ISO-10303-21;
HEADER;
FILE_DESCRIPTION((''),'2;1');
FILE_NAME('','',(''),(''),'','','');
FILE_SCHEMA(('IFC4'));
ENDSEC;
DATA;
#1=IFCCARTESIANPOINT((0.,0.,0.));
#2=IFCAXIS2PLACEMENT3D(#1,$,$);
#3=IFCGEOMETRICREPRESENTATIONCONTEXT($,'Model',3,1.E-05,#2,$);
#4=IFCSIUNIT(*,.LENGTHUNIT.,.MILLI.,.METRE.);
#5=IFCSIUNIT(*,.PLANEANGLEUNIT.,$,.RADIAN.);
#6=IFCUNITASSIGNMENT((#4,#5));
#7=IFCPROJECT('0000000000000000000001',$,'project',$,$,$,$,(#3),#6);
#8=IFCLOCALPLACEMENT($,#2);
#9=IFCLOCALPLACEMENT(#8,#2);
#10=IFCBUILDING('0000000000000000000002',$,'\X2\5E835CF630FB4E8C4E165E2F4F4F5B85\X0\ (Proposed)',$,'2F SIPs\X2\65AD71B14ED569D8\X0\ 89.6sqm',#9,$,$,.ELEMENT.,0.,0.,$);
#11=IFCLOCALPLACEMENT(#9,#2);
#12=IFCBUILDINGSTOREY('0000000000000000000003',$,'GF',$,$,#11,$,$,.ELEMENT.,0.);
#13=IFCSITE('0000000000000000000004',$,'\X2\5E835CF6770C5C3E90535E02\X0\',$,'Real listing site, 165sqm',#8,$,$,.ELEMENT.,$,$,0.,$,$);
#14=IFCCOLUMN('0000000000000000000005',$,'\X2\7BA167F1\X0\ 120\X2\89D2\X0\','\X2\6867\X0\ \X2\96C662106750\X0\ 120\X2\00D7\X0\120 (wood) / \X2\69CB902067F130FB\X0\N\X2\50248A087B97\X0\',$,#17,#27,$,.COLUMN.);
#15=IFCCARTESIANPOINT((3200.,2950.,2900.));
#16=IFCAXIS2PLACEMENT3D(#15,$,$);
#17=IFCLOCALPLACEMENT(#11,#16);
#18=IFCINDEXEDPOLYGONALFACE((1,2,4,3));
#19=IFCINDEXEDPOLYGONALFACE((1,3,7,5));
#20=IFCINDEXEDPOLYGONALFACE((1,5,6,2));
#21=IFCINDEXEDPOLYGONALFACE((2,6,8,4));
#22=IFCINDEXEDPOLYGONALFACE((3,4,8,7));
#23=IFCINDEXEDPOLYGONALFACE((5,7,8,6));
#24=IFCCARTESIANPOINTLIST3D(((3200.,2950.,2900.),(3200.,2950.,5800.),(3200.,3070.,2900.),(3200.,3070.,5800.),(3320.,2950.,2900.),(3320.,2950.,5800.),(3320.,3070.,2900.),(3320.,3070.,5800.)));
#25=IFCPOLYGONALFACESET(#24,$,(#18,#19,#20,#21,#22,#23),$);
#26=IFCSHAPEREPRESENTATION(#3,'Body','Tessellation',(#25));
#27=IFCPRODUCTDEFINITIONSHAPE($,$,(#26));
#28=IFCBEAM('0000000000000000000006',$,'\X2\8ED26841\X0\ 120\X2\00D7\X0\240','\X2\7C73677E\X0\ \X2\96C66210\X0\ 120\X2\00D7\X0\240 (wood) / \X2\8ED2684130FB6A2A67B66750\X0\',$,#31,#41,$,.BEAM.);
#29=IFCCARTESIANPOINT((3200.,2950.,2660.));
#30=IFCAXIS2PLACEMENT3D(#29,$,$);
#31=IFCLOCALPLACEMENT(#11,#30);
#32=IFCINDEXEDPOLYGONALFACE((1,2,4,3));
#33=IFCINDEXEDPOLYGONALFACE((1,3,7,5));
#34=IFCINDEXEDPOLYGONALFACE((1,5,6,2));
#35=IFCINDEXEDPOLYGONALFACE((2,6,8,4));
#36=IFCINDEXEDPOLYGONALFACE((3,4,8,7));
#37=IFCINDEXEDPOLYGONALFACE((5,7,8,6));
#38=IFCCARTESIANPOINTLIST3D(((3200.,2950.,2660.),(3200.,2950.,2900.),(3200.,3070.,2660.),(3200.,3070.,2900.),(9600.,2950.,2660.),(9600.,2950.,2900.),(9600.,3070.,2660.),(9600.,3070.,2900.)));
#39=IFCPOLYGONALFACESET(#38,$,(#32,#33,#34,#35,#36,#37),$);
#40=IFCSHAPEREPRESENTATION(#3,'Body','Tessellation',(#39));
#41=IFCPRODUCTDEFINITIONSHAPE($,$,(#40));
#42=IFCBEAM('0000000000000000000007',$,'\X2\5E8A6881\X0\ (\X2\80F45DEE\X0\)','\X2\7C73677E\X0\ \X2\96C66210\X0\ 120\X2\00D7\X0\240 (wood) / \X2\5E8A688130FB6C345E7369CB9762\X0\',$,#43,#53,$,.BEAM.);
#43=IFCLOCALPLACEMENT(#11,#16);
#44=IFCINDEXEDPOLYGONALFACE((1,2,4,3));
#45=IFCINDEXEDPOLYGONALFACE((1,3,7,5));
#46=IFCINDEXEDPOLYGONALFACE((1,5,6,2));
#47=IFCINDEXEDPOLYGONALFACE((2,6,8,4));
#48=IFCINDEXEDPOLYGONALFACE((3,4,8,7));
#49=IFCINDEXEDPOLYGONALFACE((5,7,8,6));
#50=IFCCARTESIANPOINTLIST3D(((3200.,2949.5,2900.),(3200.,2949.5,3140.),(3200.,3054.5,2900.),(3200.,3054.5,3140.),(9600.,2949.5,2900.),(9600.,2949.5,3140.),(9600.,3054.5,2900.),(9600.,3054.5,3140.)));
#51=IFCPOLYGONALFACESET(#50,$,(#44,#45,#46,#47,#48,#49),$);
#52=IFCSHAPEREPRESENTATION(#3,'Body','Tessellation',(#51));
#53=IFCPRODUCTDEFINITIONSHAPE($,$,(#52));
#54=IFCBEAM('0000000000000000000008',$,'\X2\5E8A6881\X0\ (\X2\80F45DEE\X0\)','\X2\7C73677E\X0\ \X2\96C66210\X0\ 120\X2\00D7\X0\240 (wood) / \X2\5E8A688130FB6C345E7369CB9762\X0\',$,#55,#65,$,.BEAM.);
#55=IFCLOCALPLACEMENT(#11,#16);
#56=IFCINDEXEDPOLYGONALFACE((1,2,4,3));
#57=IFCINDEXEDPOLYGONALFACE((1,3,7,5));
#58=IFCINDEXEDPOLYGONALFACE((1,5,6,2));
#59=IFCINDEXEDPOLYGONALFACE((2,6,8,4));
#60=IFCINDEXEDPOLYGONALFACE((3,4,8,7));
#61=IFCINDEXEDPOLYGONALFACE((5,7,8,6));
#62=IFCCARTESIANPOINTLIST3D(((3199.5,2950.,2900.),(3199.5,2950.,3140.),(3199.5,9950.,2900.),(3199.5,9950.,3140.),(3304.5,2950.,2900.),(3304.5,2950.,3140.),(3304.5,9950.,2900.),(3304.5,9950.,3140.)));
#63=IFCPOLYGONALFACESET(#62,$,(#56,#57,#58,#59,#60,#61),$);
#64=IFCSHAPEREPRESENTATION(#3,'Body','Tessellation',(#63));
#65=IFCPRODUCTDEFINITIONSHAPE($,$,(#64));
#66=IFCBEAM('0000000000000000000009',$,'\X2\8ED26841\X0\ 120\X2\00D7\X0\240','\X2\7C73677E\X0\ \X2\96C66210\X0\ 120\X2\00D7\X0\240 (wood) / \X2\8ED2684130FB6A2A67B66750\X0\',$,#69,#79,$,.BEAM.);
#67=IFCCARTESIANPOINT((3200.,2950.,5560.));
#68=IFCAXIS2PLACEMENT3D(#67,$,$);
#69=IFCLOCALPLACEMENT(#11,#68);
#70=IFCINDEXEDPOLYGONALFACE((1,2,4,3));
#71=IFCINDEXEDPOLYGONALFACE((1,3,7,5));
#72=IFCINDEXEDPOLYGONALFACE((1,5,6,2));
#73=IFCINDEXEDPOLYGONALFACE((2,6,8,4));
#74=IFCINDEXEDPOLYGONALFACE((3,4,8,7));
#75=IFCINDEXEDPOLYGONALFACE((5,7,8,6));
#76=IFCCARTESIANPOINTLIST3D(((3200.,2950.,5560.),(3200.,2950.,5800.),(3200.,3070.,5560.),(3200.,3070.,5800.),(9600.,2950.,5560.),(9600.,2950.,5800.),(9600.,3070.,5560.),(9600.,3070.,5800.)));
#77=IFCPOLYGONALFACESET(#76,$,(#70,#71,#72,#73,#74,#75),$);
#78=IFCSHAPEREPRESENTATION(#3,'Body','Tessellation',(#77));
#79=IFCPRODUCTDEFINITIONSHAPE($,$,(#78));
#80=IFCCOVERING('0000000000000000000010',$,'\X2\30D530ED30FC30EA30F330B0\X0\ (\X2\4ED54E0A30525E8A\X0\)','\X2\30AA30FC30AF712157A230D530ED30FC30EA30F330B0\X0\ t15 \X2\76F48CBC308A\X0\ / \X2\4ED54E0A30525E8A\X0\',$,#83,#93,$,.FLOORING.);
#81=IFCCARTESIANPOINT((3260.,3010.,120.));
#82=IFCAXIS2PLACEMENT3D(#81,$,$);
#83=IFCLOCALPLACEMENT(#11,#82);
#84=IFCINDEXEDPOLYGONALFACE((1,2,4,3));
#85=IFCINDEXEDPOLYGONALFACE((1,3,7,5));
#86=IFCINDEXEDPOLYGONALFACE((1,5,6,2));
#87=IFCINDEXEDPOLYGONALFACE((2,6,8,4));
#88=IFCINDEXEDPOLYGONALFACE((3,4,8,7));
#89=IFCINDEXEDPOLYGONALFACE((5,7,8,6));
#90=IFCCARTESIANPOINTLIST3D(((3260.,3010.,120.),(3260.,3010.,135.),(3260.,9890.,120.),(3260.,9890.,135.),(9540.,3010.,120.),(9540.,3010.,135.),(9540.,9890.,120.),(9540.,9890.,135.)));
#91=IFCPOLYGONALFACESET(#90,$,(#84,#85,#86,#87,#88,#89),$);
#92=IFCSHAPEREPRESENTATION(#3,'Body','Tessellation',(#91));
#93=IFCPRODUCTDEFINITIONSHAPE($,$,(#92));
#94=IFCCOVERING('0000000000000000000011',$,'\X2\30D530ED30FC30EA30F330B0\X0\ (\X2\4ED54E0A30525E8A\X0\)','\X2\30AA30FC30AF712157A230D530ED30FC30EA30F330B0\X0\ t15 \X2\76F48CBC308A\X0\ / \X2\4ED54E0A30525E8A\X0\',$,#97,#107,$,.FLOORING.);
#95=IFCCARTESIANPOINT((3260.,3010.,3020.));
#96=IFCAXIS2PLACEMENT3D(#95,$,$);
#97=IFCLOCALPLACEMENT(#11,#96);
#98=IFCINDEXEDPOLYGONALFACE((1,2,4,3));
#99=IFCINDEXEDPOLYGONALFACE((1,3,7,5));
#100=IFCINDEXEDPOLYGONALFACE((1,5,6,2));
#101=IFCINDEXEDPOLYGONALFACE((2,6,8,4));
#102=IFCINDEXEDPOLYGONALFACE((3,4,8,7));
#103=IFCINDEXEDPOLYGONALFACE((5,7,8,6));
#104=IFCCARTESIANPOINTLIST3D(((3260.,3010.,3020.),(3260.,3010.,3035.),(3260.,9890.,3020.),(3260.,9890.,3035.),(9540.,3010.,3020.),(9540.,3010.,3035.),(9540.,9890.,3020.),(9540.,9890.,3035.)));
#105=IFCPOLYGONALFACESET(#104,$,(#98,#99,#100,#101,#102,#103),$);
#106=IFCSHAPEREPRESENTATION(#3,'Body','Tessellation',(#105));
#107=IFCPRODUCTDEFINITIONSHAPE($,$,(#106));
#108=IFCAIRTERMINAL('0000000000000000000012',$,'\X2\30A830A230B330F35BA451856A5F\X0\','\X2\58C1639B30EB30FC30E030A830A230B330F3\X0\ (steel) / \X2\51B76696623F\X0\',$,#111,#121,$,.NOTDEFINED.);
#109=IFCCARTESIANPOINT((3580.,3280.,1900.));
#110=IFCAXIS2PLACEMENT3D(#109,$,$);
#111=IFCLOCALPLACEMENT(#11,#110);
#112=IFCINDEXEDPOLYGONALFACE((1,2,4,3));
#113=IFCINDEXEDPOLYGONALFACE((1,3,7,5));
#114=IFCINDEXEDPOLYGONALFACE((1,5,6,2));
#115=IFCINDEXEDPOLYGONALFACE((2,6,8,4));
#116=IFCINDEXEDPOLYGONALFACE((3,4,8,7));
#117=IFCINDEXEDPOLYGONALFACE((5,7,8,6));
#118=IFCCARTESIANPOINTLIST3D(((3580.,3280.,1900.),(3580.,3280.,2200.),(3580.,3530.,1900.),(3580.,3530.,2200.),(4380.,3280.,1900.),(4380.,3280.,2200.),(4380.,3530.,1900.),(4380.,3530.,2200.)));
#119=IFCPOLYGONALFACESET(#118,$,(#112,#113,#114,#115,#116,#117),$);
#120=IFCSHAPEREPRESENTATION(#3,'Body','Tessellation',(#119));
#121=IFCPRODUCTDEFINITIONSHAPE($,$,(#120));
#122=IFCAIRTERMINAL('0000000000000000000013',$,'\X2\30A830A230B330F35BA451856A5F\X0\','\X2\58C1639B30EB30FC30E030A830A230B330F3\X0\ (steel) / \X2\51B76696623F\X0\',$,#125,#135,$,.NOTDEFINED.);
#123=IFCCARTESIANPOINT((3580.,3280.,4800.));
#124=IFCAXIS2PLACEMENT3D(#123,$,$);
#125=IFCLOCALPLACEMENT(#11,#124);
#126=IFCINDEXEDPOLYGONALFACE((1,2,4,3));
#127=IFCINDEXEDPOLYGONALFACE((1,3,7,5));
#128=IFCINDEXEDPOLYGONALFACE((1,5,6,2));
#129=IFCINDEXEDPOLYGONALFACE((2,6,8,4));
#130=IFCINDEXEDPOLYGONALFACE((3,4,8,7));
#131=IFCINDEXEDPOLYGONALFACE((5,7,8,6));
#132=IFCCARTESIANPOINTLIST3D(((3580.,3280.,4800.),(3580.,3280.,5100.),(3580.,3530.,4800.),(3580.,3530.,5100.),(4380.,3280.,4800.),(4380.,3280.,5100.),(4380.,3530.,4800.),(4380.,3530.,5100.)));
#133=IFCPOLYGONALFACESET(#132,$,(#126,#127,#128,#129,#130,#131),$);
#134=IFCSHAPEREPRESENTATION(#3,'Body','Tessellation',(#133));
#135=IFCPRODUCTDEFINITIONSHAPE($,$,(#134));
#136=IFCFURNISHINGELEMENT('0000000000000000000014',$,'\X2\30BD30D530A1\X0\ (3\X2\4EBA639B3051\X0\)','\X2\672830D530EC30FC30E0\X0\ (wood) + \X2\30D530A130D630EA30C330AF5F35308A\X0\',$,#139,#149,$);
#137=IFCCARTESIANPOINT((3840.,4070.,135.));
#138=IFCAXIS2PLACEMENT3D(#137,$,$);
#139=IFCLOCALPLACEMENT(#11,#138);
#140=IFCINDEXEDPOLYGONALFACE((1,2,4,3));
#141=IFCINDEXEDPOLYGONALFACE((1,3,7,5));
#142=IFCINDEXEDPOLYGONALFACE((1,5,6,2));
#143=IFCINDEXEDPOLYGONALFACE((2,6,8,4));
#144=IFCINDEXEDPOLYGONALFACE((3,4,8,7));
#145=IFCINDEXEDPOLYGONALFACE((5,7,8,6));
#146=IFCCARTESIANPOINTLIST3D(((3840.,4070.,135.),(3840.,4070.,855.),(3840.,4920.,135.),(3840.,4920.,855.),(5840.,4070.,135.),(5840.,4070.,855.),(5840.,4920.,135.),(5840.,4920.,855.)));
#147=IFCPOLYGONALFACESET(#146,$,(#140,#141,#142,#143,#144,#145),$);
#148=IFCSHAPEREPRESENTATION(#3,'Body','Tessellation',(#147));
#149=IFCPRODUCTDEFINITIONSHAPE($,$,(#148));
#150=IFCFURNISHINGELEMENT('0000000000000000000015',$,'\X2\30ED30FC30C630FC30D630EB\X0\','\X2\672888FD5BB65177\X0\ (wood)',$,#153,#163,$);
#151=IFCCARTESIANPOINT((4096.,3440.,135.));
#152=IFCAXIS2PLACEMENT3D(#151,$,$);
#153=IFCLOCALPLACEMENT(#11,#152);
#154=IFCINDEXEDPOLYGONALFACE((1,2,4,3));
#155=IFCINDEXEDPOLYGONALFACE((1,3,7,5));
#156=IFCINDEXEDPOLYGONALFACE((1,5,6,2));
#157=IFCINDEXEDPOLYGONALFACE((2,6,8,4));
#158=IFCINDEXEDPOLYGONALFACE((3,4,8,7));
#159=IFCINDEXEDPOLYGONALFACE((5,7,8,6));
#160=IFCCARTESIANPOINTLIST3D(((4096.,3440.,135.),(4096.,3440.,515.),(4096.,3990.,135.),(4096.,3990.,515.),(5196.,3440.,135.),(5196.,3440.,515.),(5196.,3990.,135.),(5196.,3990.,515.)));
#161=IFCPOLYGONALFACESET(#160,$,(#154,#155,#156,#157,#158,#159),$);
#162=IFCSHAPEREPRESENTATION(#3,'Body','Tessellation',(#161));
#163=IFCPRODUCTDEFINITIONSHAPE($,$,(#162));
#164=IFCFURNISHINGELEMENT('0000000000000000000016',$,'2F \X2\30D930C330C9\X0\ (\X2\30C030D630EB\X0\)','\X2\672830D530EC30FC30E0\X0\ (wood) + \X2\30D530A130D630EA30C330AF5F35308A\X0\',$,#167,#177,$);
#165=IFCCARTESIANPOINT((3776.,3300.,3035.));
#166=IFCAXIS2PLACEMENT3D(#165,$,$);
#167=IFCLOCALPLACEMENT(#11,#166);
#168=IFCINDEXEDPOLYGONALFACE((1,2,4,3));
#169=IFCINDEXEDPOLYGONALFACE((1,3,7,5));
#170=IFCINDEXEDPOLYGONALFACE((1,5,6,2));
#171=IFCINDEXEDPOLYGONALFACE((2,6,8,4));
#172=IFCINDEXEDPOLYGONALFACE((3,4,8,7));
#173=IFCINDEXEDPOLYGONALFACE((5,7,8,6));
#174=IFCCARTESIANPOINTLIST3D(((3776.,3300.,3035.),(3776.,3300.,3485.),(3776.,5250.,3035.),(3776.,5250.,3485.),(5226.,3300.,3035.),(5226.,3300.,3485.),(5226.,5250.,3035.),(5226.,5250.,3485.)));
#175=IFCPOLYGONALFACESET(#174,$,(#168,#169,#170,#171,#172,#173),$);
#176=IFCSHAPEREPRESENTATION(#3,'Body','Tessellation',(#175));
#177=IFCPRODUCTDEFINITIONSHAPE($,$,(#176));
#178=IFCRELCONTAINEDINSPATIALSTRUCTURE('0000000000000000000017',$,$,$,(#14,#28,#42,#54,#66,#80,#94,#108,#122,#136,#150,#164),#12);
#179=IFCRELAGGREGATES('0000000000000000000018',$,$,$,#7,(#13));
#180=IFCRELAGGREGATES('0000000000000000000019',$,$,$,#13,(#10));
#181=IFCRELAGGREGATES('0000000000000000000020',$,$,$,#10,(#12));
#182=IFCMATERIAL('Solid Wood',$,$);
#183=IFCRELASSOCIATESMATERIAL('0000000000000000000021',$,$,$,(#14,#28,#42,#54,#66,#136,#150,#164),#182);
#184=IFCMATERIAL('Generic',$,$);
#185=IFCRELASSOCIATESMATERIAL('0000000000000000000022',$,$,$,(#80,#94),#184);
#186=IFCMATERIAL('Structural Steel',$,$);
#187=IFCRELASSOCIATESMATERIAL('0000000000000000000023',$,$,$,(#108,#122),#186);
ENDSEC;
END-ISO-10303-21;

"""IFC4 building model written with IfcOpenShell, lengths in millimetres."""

from ifc_helpers import new_model, si_unit, frame, frame_2d, origin, place, context, project, spatial, rectangle, extrude, material, element, save


model = new_model("IFC4")

# Units and contexts
model_context = context("Model", 3, precision=1e-05, world=origin())
ifc_project = project(units=[si_unit("LENGTHUNIT", "METRE", prefix="MILLI"), si_unit("PLANEANGLEUNIT", "RADIAN")], contexts=[model_context])

# Site, building, storey
site_placement = place(None, origin())
site = spatial("IfcSite", under=ifc_project, at=site_placement, Name="広島県尾道市", ObjectType="Real listing site, 165sqm", CompositionType="ELEMENT", RefElevation=0.0)
building_placement = place(site_placement, origin())
building = spatial("IfcBuilding", under=site, at=building_placement, Name="広島・二世帯住宅 (Proposed)", ObjectType="2F SIPs断熱仕様 89.6sqm", CompositionType="ELEMENT", ElevationOfRefHeight=0.0, ElevationOfTerrain=0.0)
storey_placement = place(building_placement, origin())
storey = spatial("IfcBuildingStorey", under=building, at=storey_placement, Name="GF", CompositionType="ELEMENT", Elevation=0.0)

# Column
ifc_material_1 = material(Name="Solid Wood")
column_placement = place(storey_placement, frame((3200.0, 2950.0, 2900.0)))
element("IfcColumn", 1, at=column_placement, inside=storey, material=ifc_material_1, Name="管柱 120角", Description="桧 集成材 120×120 (wood) / 構造柱・N値計算", PredefinedType="COLUMN", context=model_context, shape_type="SweptSolid", body=[
    extrude(rectangle(XDim=120.0, YDim=120.0, at=frame_2d((60.0, 60.0))), frame((3200.0, 2950.0, 2900.0)), (0.0, 0.0, 1.0), 2900.0),
])

# Beams
beam_1_placement = place(storey_placement, frame((3200.0, 2950.0, 2660.0)))
element("IfcBeam", 2, at=beam_1_placement, inside=storey, material=ifc_material_1, Name="軒桁 120×240", Description="米松 集成 120×240 (wood) / 軒桁・横架材", PredefinedType="BEAM", context=model_context, shape_type="SweptSolid", body=[
    extrude(rectangle(XDim=6400.0, YDim=120.0, at=frame_2d((3200.0, 60.0))), frame((3200.0, 2950.0, 2660.0)), (0.0, 0.0, 1.0), 240.0),
])
beam_2_placement = place(storey_placement, frame((3200.0, 2950.0, 2900.0)))
element("IfcBeam", 3, at=beam_2_placement, inside=storey, material=ifc_material_1, Name="床梁 (胴差)", Description="米松 集成 120×240 (wood) / 床梁・水平構面", PredefinedType="BEAM", context=model_context, shape_type="SweptSolid", body=[
    extrude(rectangle(XDim=6400.0, YDim=105.0, at=frame_2d((3200.0, 52.0))), frame((3200.0, 2950.0, 2900.0)), (0.0, 0.0, 1.0), 240.0),
])
beam_3_placement = place(storey_placement, frame((3200.0, 2950.0, 2900.0)))
element("IfcBeam", 4, at=beam_3_placement, inside=storey, material=ifc_material_1, Name="床梁 (胴差)", Description="米松 集成 120×240 (wood) / 床梁・水平構面", PredefinedType="BEAM", context=model_context, shape_type="SweptSolid", body=[
    extrude(rectangle(XDim=105.0, YDim=7000.0, at=frame_2d((52.0, 3500.0))), frame((3200.0, 2950.0, 2900.0)), (0.0, 0.0, 1.0), 240.0),
])
beam_4_placement = place(storey_placement, frame((3200.0, 2950.0, 5560.0)))
element("IfcBeam", 5, at=beam_4_placement, inside=storey, material=ifc_material_1, Name="軒桁 120×240", Description="米松 集成 120×240 (wood) / 軒桁・横架材", PredefinedType="BEAM", context=model_context, shape_type="SweptSolid", body=[
    extrude(rectangle(XDim=6400.0, YDim=120.0, at=frame_2d((3200.0, 60.0))), frame((3200.0, 2950.0, 5560.0)), (0.0, 0.0, 1.0), 240.0),
])

# Coverings
ifc_material_2 = material(Name="Generic")
covering_1_placement = place(storey_placement, frame((3260.0, 3010.0, 120.0)))
element("IfcCovering", 6, at=covering_1_placement, inside=storey, material=ifc_material_2, Name="フローリング (仕上げ床)", Description="オーク無垢フローリング t15 直貼り / 仕上げ床", PredefinedType="FLOORING", context=model_context, shape_type="SweptSolid", body=[
    extrude(rectangle(XDim=6280.0, YDim=6880.0, at=frame_2d((3140.0, 3440.0))), frame((3260.0, 3010.0, 120.0)), (0.0, 0.0, 1.0), 15.0),
])
covering_2_placement = place(storey_placement, frame((3260.0, 3010.0, 3020.0)))
element("IfcCovering", 7, at=covering_2_placement, inside=storey, material=ifc_material_2, Name="フローリング (仕上げ床)", Description="オーク無垢フローリング t15 直貼り / 仕上げ床", PredefinedType="FLOORING", context=model_context, shape_type="SweptSolid", body=[
    extrude(rectangle(XDim=6280.0, YDim=6880.0, at=frame_2d((3140.0, 3440.0))), frame((3260.0, 3010.0, 3020.0)), (0.0, 0.0, 1.0), 15.0),
])

# Air terminals
ifc_material_3 = material(Name="Structural Steel")
air_terminal_1_placement = place(storey_placement, frame((3580.0, 3280.0, 1900.0)))
element("IfcAirTerminal", 8, at=air_terminal_1_placement, inside=storey, material=ifc_material_3, Name="エアコン室内機", Description="壁掛ルームエアコン (steel) / 冷暖房", PredefinedType="NOTDEFINED", context=model_context, shape_type="SweptSolid", body=[
    extrude(rectangle(XDim=800.0, YDim=250.0, at=frame_2d((400.0, 125.0))), frame((3580.0, 3280.0, 1900.0)), (0.0, 0.0, 1.0), 300.0),
])
air_terminal_2_placement = place(storey_placement, frame((3580.0, 3280.0, 4800.0)))
element("IfcAirTerminal", 9, at=air_terminal_2_placement, inside=storey, material=ifc_material_3, Name="エアコン室内機", Description="壁掛ルームエアコン (steel) / 冷暖房", PredefinedType="NOTDEFINED", context=model_context, shape_type="SweptSolid", body=[
    extrude(rectangle(XDim=800.0, YDim=250.0, at=frame_2d((400.0, 125.0))), frame((3580.0, 3280.0, 4800.0)), (0.0, 0.0, 1.0), 300.0),
])

# Furnishing elements
furnishing_1_placement = place(storey_placement, frame((3840.0, 4070.0, 135.0)))
element("IfcFurnishingElement", 10, at=furnishing_1_placement, inside=storey, material=ifc_material_1, Name="ソファ (3人掛け)", Description="木フレーム (wood) + ファブリック張り", context=model_context, shape_type="SweptSolid", body=[
    extrude(rectangle(XDim=2000.0, YDim=850.0, at=frame_2d((1000.0, 425.0))), frame((3840.0, 4070.0, 135.0)), (0.0, 0.0, 1.0), 720.0),
])
furnishing_2_placement = place(storey_placement, frame((4096.0, 3440.0, 135.0)))
element("IfcFurnishingElement", 11, at=furnishing_2_placement, inside=storey, material=ifc_material_1, Name="ローテーブル", Description="木製家具 (wood)", context=model_context, shape_type="SweptSolid", body=[
    extrude(rectangle(XDim=1100.0, YDim=550.0, at=frame_2d((550.0, 275.0))), frame((4096.0, 3440.0, 135.0)), (0.0, 0.0, 1.0), 380.0),
])
furnishing_3_placement = place(storey_placement, frame((3776.0, 3300.0, 3035.0)))
element("IfcFurnishingElement", 12, at=furnishing_3_placement, inside=storey, material=ifc_material_1, Name="2F ベッド (ダブル)", Description="木フレーム (wood) + ファブリック張り", context=model_context, shape_type="SweptSolid", body=[
    extrude(rectangle(XDim=1450.0, YDim=1950.0, at=frame_2d((725.0, 975.0))), frame((3776.0, 3300.0, 3035.0)), (0.0, 0.0, 1.0), 450.0),
])

save(model, "model.ifc")
